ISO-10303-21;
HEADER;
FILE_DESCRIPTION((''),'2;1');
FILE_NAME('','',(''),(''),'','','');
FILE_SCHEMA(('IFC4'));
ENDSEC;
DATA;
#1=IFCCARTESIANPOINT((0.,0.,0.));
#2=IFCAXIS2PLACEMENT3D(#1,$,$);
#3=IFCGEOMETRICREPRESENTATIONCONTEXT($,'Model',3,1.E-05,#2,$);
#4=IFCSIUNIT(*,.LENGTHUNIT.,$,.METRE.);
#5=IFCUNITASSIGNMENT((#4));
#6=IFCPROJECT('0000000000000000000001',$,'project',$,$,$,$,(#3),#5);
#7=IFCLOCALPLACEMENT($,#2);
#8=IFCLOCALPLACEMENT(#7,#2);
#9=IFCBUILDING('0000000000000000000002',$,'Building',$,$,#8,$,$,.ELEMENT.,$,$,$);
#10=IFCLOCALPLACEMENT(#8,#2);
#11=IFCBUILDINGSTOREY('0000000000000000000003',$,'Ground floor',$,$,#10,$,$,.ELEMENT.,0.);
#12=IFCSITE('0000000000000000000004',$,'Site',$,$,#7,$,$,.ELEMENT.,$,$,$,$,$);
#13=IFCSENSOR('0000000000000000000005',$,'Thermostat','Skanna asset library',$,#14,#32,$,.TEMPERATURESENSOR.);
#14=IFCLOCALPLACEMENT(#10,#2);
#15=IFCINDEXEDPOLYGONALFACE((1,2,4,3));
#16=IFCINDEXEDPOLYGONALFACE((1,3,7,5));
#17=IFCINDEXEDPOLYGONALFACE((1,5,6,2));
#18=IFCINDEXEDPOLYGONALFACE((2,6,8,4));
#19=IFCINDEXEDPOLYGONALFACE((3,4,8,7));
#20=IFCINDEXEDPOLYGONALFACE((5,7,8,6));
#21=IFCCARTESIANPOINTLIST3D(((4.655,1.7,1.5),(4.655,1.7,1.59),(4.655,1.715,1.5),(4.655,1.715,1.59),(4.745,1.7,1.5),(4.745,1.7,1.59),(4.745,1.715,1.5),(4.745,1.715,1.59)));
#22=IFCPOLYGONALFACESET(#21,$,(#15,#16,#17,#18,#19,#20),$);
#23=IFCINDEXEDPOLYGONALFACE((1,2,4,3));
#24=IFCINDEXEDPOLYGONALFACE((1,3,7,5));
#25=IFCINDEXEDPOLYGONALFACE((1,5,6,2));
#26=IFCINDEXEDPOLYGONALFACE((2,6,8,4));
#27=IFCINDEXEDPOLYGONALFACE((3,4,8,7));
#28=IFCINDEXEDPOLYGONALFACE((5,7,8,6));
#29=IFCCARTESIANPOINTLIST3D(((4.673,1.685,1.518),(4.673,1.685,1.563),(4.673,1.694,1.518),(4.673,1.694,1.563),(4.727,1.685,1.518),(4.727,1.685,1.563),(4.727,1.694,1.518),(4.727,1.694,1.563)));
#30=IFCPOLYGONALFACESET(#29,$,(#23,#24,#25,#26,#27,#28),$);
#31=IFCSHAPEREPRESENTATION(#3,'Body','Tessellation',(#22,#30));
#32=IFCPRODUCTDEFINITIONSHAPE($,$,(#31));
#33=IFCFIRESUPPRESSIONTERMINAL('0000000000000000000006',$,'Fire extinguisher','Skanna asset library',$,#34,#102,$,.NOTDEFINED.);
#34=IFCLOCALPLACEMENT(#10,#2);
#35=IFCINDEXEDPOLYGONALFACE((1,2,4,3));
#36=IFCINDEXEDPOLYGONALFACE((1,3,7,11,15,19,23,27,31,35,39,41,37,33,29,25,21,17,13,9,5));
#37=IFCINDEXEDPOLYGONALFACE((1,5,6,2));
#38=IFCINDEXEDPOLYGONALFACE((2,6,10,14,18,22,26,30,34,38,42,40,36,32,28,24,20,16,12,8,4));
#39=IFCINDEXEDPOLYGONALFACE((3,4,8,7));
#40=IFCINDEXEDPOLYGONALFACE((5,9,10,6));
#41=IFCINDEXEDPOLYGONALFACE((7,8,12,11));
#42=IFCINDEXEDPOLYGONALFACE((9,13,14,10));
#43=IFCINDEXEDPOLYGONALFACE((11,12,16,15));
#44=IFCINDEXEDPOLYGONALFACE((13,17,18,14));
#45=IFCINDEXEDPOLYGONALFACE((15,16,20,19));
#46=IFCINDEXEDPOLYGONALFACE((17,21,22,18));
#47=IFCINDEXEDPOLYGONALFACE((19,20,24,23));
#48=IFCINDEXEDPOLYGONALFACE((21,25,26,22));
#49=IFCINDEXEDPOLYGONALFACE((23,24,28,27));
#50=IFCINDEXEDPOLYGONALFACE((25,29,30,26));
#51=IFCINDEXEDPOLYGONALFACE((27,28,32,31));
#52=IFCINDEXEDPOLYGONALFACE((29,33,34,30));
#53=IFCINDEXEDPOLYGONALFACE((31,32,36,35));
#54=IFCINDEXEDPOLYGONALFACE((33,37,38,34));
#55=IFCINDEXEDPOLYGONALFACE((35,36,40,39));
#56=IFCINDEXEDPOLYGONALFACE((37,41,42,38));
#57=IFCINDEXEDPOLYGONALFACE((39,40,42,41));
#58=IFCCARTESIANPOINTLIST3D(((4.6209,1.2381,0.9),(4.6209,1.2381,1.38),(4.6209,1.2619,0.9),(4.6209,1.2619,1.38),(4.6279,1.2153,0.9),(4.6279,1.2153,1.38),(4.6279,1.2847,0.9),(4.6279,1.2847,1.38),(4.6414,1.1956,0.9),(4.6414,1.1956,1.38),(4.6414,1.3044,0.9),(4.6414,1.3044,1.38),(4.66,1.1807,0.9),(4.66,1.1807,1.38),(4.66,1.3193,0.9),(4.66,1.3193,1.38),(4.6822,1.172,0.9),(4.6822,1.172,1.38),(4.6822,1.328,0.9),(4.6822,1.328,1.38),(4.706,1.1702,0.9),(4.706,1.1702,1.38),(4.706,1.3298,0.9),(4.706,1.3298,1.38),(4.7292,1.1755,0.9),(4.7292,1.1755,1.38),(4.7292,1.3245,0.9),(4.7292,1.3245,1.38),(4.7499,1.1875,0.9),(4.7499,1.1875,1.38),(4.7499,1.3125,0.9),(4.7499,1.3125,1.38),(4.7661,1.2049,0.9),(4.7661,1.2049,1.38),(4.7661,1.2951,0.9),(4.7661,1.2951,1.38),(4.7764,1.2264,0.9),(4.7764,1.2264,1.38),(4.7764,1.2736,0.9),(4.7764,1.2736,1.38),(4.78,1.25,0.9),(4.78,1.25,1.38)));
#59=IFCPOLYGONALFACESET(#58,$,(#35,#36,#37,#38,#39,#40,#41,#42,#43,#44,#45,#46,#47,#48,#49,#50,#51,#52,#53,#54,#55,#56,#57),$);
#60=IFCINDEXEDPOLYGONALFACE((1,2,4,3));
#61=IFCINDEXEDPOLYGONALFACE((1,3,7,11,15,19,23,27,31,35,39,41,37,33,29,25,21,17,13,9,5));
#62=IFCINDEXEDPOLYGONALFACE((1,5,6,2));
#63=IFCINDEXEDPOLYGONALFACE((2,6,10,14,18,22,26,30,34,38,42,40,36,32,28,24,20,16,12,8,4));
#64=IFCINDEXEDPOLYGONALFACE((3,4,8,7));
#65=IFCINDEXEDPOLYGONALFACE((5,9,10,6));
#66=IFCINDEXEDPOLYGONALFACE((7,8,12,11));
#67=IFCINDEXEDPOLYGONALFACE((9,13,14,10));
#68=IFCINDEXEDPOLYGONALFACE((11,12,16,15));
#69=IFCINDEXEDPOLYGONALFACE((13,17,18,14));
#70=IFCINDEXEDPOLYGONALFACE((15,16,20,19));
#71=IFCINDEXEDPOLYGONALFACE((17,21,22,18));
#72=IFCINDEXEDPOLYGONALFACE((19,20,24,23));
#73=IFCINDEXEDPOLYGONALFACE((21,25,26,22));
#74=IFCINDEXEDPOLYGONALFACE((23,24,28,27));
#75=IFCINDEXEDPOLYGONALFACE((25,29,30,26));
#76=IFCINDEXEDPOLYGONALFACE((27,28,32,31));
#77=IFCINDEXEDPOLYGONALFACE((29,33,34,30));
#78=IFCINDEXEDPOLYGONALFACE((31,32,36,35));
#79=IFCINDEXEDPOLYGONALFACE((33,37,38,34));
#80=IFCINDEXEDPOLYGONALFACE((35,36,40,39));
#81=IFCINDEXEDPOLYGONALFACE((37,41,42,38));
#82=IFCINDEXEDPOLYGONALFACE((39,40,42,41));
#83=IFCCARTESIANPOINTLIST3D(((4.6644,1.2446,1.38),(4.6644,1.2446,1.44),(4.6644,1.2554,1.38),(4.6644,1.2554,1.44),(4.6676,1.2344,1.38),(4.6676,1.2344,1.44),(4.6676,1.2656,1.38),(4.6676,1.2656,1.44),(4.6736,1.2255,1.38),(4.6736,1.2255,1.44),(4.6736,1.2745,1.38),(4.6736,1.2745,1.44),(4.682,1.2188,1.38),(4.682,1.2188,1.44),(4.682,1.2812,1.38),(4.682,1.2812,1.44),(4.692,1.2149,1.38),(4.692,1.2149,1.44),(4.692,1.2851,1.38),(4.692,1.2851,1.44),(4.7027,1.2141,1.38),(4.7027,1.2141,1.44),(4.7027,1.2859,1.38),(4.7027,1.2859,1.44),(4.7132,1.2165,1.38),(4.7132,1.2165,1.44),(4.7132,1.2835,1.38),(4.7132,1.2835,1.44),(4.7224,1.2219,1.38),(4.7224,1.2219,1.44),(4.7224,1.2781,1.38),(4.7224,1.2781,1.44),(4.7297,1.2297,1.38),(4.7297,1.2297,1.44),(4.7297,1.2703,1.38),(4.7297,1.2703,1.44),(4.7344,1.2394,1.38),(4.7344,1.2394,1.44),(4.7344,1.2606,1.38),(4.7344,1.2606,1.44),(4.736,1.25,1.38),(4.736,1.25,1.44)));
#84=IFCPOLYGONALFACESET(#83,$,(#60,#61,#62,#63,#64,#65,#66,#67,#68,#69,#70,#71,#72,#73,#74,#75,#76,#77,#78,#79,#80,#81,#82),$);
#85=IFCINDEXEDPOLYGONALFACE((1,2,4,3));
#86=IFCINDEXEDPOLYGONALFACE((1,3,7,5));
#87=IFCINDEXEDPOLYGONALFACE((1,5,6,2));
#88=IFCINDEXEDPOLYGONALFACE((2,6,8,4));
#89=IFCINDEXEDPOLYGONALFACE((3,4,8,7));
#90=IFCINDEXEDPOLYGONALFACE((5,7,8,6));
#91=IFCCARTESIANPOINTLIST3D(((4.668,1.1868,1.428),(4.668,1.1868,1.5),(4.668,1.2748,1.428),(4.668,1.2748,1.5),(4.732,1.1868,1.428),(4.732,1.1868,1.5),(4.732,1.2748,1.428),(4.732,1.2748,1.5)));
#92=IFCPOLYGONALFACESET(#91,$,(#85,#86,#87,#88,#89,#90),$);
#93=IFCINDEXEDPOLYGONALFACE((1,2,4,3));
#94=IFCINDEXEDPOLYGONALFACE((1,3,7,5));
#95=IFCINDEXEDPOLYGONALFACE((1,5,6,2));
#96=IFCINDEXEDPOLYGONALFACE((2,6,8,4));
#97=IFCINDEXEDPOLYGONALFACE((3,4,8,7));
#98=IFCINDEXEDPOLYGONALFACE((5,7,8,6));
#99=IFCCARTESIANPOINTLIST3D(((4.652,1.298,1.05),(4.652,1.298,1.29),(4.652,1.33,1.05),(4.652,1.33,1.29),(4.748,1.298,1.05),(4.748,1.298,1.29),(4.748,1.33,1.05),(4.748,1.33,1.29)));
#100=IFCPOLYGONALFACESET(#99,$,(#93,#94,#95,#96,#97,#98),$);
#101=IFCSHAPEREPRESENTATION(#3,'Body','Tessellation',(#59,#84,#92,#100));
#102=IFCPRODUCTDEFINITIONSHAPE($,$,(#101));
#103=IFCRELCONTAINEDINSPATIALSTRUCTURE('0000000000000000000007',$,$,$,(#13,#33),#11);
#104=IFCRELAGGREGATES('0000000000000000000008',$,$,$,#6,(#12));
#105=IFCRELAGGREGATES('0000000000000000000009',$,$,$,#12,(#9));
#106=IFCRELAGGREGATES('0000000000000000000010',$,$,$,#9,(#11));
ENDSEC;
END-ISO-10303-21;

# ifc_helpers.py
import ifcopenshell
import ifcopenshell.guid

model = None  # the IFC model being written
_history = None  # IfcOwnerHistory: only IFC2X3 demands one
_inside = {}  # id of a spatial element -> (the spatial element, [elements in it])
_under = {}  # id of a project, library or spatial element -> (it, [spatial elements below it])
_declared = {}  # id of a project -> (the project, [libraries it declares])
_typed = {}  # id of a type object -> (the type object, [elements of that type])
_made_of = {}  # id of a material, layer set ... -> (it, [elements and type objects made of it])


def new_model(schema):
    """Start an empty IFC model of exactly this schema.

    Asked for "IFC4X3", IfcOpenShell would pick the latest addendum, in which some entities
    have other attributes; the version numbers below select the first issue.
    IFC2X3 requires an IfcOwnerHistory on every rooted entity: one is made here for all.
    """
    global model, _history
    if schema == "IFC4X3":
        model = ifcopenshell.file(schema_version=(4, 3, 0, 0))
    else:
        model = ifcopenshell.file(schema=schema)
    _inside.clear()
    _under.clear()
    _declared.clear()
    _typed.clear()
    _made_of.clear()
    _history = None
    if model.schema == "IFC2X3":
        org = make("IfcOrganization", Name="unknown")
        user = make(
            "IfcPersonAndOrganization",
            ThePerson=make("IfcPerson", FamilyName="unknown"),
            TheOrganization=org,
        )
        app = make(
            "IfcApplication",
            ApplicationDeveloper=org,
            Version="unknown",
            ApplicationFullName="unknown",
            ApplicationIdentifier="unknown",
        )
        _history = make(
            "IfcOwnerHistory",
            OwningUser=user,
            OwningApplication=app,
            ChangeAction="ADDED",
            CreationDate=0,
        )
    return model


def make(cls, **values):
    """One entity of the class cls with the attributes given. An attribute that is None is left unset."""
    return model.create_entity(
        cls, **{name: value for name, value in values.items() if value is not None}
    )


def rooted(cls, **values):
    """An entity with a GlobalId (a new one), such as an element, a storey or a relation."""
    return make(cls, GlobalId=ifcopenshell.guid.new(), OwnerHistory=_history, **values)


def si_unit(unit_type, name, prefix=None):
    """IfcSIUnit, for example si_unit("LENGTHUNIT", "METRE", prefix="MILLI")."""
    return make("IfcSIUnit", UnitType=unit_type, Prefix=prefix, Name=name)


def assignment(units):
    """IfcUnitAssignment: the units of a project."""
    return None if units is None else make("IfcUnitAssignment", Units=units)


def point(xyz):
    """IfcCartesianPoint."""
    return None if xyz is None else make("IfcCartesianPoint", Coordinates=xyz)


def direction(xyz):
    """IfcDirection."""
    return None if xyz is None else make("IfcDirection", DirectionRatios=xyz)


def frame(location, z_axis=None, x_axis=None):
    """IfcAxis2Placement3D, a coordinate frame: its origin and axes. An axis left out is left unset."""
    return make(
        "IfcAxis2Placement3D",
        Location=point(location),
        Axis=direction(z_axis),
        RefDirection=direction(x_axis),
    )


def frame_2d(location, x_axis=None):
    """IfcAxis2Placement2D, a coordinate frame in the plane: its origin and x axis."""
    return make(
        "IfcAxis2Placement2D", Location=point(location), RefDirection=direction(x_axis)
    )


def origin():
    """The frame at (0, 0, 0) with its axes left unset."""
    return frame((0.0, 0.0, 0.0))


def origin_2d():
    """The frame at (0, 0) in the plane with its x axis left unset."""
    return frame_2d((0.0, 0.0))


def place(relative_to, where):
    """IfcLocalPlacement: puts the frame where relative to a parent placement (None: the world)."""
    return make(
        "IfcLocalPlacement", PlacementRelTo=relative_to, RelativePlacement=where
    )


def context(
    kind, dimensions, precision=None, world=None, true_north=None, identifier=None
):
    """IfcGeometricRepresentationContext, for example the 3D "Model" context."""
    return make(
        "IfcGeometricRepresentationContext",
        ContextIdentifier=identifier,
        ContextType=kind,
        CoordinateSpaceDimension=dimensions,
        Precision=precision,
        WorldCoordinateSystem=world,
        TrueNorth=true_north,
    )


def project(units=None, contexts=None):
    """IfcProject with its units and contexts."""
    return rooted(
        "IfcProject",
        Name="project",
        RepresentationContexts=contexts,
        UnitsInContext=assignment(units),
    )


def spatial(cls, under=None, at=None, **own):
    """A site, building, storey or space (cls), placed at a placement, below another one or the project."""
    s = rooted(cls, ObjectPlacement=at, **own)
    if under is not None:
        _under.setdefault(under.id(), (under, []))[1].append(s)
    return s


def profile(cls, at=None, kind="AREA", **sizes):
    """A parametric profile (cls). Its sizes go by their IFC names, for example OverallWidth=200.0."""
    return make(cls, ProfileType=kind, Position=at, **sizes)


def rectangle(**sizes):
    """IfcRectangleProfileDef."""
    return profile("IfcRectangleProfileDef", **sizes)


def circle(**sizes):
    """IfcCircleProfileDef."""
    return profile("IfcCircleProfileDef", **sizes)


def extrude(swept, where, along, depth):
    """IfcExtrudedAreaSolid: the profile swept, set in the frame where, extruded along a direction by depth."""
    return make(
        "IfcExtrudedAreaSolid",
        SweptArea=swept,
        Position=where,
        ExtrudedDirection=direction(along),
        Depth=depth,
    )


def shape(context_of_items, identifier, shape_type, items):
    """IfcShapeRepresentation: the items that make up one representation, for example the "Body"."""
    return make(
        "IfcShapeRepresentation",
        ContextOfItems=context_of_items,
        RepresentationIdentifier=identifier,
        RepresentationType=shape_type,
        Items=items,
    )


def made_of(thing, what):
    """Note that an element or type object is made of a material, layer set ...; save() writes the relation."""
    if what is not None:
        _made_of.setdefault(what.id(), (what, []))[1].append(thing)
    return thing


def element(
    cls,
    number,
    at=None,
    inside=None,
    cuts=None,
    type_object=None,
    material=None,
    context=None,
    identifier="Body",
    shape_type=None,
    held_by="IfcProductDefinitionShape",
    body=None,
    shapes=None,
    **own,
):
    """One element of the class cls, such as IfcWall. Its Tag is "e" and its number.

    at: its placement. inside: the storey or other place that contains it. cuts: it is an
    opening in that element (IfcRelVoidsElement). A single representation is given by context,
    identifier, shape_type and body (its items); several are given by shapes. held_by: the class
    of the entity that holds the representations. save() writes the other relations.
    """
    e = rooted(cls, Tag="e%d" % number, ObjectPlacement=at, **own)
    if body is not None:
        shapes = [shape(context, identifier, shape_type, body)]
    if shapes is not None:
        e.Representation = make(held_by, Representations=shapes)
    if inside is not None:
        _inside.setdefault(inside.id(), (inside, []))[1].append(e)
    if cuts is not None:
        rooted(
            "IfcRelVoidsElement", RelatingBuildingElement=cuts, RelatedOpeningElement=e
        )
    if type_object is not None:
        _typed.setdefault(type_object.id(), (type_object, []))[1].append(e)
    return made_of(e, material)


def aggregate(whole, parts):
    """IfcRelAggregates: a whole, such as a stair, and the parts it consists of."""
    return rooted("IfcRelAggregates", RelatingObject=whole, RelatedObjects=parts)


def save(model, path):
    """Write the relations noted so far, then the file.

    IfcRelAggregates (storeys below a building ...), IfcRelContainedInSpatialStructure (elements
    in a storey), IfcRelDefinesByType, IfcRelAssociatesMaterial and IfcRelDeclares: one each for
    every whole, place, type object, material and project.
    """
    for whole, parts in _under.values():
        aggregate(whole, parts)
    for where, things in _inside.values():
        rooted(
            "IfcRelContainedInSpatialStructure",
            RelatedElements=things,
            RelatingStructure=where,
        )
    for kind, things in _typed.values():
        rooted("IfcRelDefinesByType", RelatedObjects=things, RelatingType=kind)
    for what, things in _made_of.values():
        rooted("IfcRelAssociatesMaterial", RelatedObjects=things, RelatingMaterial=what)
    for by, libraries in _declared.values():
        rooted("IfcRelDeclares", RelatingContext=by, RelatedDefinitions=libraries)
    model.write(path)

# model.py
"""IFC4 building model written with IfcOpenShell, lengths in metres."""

from ifc_helpers import new_model, si_unit, frame, frame_2d, origin, origin_2d, place, context, project, spatial, rectangle, circle, extrude, element, save


model = new_model("IFC4")

# Units and contexts
model_context = context("Model", 3, precision=1e-05, world=origin())
ifc_project = project(units=[si_unit("LENGTHUNIT", "METRE")], contexts=[model_context])

# Site, building, storey
site_placement = place(None, origin())
site = spatial("IfcSite", under=ifc_project, at=site_placement, Name="Site", CompositionType="ELEMENT")
building_placement = place(site_placement, origin())
building = spatial("IfcBuilding", under=site, at=building_placement, Name="Building", CompositionType="ELEMENT")
storey_placement = place(building_placement, origin())
storey = spatial("IfcBuildingStorey", under=building, at=storey_placement, Name="Ground floor", CompositionType="ELEMENT", Elevation=0.0)

# Sensor
sensor_placement = place(storey_placement, frame((4.7, 1.7, 1.5), z_axis=(0.0, 0.0, 1.0), x_axis=(1.0, 0.0, 0.0)))
element("IfcSensor", 1, at=sensor_placement, inside=storey, Name="Thermostat", Description="Skanna asset library", PredefinedType="TEMPERATURESENSOR", context=model_context, shape_type="SweptSolid", body=[
    extrude(rectangle(XDim=0.09, YDim=0.015, at=frame_2d((0.0, 0.0075))), origin(), (0.0, 0.0, 1.0), 0.09),
    extrude(rectangle(XDim=0.054, YDim=0.009, at=frame_2d((0.0, -0.0105))), frame((0.0, 0.0, 0.018)), (0.0, 0.0, 1.0), 0.045),
])

# Fire suppression terminal
fire_suppression_terminal_placement = place(storey_placement, frame((4.7, 1.25, 0.9), z_axis=(0.0, 0.0, 1.0), x_axis=(1.0, 0.0, 0.0)))
element("IfcFireSuppressionTerminal", 2, at=fire_suppression_terminal_placement, inside=storey, Name="Fire extinguisher", Description="Skanna asset library", PredefinedType="NOTDEFINED", context=model_context, shape_type="SweptSolid", body=[
    extrude(circle(Radius=0.08, at=origin_2d()), origin(), (0.0, 0.0, 1.0), 0.48),
    extrude(circle(Radius=0.036, at=origin_2d()), frame((0.0, 0.0, 0.48)), (0.0, 0.0, 1.0), 0.06),
    extrude(rectangle(XDim=0.064, YDim=0.088, at=frame_2d((0.0, -0.0192))), frame((0.0, 0.0, 0.528)), (0.0, 0.0, 1.0), 0.072),
    extrude(rectangle(XDim=0.096, YDim=0.032, at=frame_2d((0.0, 0.064))), frame((0.0, 0.0, 0.15)), (0.0, 0.0, 1.0), 0.24),
])

save(model, "model.ifc")
